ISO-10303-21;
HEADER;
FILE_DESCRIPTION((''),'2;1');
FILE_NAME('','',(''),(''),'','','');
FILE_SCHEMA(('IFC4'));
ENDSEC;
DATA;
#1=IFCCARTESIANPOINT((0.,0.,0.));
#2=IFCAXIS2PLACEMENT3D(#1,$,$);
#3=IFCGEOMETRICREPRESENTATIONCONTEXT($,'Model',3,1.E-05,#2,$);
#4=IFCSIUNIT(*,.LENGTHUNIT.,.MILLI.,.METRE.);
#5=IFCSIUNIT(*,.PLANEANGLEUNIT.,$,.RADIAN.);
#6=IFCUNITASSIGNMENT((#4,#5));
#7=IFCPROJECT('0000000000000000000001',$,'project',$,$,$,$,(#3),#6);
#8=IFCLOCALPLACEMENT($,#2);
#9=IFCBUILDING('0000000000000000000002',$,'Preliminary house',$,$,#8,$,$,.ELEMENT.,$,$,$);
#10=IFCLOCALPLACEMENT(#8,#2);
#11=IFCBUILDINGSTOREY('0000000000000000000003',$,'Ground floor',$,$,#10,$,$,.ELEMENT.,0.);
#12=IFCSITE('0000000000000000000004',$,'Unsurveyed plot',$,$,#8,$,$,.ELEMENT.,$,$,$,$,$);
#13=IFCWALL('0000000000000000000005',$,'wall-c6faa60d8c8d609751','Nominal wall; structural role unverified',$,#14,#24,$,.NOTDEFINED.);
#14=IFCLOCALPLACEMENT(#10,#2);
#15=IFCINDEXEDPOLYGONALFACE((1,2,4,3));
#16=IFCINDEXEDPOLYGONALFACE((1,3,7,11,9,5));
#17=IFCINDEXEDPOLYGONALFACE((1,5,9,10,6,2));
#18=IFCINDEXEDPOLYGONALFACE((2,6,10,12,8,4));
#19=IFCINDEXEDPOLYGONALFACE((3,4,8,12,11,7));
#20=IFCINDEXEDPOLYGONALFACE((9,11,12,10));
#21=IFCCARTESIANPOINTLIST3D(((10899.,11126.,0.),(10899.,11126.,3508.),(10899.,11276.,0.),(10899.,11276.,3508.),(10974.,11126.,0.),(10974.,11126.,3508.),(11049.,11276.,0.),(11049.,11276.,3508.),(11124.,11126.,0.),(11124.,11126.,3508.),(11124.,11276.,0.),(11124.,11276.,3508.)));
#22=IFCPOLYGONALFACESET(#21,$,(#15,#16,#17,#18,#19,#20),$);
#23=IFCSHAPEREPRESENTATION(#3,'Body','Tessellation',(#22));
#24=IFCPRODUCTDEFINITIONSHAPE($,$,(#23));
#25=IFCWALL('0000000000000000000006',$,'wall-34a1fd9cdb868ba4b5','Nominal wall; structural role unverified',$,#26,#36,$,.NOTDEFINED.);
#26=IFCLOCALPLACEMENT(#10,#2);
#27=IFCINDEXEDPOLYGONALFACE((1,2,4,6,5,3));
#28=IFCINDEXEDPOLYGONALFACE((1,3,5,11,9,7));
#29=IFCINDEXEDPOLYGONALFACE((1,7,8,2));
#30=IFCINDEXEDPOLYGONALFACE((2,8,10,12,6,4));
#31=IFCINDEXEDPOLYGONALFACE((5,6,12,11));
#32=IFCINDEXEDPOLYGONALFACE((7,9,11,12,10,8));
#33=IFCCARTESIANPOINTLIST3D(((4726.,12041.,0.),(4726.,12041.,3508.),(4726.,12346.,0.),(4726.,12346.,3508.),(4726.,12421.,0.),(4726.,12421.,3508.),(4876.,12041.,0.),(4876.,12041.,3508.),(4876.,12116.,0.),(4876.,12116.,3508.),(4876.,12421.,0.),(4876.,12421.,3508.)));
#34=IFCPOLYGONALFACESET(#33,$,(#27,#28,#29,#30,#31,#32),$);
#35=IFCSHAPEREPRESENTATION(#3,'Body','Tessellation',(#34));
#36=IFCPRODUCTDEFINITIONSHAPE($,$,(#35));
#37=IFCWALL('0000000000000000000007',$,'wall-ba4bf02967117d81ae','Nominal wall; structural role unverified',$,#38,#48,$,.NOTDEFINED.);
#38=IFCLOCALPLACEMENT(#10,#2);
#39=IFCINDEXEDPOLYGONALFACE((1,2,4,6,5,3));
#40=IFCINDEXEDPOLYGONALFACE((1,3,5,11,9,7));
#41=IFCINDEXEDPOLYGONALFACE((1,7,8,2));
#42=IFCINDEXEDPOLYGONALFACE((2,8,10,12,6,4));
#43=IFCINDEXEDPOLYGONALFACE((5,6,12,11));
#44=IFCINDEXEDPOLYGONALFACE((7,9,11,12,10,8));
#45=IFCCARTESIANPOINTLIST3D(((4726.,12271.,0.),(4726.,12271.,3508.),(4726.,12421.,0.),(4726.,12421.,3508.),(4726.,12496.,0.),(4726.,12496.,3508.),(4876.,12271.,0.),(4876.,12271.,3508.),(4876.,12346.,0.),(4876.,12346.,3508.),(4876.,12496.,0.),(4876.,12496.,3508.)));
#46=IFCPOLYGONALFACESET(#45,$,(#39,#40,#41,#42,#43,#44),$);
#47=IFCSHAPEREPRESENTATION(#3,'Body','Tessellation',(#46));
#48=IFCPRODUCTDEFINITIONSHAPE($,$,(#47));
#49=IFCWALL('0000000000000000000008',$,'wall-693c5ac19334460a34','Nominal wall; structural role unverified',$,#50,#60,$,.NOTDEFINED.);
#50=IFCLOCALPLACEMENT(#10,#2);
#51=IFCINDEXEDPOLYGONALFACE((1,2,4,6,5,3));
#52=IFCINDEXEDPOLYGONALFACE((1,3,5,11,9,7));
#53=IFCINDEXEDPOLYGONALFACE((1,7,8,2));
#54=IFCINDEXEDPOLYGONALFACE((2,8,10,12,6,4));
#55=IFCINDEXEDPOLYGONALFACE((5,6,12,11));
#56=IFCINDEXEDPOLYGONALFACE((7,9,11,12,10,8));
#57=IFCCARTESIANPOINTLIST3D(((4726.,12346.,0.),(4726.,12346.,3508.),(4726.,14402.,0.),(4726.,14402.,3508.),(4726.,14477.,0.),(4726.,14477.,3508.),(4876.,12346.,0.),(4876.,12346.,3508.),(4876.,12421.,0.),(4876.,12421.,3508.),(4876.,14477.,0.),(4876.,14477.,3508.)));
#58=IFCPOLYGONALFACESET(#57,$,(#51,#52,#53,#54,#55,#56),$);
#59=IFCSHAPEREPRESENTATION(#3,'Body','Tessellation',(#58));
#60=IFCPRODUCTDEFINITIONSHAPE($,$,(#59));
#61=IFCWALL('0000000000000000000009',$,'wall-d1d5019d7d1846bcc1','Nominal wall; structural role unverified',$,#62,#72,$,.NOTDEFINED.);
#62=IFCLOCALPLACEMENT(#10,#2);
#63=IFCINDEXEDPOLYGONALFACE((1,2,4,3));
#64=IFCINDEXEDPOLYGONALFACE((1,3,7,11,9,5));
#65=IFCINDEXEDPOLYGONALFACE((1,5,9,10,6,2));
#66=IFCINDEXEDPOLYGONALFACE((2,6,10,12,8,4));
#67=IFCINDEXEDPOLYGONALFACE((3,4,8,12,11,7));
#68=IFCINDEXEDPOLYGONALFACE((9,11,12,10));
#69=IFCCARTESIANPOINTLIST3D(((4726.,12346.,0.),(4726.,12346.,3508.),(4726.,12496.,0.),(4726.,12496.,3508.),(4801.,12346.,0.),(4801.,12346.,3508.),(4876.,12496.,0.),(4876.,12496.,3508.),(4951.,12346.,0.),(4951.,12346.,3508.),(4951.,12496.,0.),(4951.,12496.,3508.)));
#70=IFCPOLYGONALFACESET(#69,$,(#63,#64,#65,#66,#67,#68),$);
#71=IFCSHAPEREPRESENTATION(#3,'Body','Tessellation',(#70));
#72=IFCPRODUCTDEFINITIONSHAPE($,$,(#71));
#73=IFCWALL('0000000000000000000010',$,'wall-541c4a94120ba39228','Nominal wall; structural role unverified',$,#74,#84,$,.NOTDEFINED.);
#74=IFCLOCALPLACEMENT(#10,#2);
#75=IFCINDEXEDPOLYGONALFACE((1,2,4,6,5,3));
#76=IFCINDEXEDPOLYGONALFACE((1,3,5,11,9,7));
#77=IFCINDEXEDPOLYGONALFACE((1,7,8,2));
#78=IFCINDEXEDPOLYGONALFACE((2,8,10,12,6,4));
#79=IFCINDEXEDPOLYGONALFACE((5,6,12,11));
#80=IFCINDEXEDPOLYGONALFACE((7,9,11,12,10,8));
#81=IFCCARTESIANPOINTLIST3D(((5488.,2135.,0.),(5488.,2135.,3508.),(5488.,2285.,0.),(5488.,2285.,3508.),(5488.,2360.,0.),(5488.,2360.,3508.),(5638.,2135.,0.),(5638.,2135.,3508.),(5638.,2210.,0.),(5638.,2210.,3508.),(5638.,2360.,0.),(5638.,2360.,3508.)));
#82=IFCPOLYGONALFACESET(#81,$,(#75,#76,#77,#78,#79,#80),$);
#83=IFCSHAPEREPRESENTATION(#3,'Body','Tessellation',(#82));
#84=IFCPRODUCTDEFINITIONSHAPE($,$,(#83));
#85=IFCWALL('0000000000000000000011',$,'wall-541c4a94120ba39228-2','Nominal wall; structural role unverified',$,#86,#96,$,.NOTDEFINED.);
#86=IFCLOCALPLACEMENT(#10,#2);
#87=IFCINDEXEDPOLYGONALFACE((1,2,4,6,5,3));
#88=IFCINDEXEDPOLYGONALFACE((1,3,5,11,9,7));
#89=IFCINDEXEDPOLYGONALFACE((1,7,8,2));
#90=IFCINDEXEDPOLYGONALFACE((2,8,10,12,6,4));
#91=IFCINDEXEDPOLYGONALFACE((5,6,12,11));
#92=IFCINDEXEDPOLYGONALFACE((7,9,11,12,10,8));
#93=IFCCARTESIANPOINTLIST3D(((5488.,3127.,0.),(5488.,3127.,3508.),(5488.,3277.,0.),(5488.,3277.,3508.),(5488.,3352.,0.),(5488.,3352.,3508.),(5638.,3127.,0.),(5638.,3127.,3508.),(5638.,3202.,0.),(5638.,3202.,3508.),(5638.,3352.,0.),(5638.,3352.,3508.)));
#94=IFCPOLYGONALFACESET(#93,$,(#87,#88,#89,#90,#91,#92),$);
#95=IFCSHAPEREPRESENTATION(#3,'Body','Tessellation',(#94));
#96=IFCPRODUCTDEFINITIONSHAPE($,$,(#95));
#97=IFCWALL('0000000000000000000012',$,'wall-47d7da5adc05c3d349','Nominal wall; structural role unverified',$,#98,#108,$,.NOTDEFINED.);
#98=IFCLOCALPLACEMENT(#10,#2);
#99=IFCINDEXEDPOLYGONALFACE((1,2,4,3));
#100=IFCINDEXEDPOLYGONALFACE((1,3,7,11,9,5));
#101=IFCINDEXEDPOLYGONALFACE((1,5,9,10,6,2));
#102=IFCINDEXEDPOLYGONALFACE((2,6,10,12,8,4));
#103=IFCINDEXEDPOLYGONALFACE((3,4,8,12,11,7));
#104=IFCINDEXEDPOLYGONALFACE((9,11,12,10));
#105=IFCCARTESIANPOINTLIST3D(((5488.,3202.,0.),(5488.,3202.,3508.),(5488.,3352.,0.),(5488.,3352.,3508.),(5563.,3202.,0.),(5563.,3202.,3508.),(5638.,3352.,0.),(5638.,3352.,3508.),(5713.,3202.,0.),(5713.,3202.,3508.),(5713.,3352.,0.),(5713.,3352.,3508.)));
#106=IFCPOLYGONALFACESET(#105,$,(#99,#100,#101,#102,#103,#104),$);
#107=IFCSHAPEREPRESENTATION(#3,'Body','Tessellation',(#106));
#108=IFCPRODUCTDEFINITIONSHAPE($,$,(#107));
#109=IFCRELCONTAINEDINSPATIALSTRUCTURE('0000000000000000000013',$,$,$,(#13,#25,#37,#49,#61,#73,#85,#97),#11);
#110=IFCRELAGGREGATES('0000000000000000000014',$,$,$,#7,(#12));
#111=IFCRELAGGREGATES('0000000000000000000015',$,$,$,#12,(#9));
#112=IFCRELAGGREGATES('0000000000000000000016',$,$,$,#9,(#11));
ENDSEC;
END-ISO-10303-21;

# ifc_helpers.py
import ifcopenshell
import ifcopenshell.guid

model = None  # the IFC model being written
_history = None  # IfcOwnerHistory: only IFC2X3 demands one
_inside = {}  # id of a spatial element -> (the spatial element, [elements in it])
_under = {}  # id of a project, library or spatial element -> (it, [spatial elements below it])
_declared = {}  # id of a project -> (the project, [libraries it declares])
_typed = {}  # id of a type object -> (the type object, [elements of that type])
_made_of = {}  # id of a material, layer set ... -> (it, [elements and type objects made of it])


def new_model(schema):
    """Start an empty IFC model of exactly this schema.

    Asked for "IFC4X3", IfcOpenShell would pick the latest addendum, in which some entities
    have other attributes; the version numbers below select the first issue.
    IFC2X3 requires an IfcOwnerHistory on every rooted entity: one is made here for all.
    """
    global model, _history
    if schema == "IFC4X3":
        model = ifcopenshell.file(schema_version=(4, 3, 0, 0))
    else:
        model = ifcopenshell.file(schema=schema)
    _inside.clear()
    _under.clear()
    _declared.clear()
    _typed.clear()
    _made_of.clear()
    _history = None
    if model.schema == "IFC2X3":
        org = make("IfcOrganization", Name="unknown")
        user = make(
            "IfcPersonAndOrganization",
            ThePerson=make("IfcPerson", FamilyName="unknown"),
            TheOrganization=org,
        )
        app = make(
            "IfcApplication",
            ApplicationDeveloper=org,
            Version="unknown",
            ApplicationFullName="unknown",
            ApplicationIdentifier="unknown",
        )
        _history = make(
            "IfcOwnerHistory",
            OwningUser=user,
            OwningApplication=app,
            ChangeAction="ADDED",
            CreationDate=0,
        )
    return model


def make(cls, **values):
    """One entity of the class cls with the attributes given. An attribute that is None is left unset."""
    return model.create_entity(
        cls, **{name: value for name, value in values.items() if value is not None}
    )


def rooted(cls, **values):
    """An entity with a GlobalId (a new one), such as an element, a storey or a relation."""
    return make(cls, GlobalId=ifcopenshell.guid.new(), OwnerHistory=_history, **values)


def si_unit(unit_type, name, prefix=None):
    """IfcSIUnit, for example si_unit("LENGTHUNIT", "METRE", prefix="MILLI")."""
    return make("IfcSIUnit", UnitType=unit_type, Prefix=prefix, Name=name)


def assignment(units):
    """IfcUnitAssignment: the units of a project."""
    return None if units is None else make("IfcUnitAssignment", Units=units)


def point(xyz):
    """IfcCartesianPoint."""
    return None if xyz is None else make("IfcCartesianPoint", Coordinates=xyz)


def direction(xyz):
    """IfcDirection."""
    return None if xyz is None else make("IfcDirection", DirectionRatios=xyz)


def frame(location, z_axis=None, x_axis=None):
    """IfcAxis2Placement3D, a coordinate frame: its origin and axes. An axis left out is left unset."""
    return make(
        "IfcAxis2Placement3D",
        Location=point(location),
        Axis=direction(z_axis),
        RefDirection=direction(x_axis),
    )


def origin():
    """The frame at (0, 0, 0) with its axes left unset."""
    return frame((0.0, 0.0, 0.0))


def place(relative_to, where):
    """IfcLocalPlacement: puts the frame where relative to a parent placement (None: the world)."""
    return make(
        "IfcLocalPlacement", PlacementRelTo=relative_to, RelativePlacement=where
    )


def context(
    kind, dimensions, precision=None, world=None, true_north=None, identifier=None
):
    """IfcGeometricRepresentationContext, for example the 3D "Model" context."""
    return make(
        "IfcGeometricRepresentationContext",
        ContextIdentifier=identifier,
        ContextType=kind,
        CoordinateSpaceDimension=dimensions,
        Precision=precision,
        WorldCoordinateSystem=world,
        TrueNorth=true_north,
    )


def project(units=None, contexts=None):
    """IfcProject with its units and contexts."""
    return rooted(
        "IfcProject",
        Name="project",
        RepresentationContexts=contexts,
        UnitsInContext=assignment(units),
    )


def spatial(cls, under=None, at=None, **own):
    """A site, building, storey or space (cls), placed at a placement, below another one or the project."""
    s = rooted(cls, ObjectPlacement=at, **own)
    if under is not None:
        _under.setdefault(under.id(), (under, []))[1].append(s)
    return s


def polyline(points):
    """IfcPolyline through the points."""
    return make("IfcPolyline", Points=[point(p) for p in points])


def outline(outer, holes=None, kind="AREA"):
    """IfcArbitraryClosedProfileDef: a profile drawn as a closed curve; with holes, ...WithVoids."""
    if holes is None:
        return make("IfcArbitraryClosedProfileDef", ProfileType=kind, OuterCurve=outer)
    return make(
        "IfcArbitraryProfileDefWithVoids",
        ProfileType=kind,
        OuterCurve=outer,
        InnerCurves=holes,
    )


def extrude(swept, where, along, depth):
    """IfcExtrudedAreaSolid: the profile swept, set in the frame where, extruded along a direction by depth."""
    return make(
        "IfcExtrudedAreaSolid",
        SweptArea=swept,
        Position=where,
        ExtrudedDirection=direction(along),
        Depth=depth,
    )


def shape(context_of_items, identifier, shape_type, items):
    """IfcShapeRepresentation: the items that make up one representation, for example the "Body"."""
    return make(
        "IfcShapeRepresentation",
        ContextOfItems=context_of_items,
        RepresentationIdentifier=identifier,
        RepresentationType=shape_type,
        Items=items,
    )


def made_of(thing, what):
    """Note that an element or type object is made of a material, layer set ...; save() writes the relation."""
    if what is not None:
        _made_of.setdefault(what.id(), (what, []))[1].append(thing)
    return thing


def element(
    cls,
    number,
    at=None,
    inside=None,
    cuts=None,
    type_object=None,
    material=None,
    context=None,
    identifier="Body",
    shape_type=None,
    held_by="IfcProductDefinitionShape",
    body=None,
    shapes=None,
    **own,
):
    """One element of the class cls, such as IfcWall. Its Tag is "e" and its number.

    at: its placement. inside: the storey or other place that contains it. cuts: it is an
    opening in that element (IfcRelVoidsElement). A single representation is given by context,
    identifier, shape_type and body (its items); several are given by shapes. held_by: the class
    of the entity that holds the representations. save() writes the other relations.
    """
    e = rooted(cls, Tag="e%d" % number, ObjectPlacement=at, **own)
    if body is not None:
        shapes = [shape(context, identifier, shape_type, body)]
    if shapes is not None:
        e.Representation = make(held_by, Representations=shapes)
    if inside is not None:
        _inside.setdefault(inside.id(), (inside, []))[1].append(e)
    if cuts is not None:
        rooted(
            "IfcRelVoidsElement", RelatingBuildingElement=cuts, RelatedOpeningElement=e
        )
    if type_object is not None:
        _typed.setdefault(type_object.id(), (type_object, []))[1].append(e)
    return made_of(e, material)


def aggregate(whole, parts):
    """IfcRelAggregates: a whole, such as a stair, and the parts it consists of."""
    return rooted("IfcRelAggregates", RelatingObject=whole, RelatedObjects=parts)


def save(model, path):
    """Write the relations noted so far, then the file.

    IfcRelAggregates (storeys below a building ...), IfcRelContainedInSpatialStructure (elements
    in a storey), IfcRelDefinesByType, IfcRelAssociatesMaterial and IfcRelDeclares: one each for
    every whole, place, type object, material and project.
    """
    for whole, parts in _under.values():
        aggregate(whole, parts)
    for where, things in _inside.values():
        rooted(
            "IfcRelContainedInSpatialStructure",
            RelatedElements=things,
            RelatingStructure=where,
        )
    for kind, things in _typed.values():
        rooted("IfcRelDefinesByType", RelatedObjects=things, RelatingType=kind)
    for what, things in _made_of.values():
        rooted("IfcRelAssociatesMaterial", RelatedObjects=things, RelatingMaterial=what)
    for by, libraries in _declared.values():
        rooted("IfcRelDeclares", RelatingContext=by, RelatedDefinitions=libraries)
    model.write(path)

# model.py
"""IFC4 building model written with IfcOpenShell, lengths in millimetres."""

from ifc_helpers import new_model, si_unit, origin, place, context, project, spatial, polyline, outline, extrude, element, save


model = new_model("IFC4")

# Units and contexts
model_context = context("Model", 3, precision=1e-05, world=origin())
ifc_project = project(units=[si_unit("LENGTHUNIT", "METRE", prefix="MILLI"), si_unit("PLANEANGLEUNIT", "RADIAN")], contexts=[model_context])

# Site, building, storey
placement_1 = place(None, origin())
site = spatial("IfcSite", under=ifc_project, at=placement_1, Name="Unsurveyed plot", CompositionType="ELEMENT")
building = spatial("IfcBuilding", under=site, at=placement_1, Name="Preliminary house", CompositionType="ELEMENT")
placement_2 = place(placement_1, origin())
storey = spatial("IfcBuildingStorey", under=building, at=placement_2, Name="Ground floor", CompositionType="ELEMENT", Elevation=0.0)

# Walls
element("IfcWall", 1, at=placement_2, inside=storey, Name="wall-c6faa60d8c8d609751", Description="Nominal wall; structural role unverified", PredefinedType="NOTDEFINED", context=model_context, shape_type="SweptSolid", body=[
    extrude(outline(polyline([(11049.0, 11276.0), (11124.0, 11276.0), (11124.0, 11126.0), (10974.0, 11126.0), (10899.0, 11126.0), (10899.0, 11276.0), (11049.0, 11276.0)])), origin(), (0.0, 0.0, 1.0), 3508.0),
])
element("IfcWall", 2, at=placement_2, inside=storey, Name="wall-34a1fd9cdb868ba4b5", Description="Nominal wall; structural role unverified", PredefinedType="NOTDEFINED", context=model_context, shape_type="SweptSolid", body=[
    extrude(outline(polyline([(4726.0, 12346.0), (4726.0, 12421.0), (4876.0, 12421.0), (4876.0, 12116.0), (4876.0, 12041.0), (4726.0, 12041.0), (4726.0, 12346.0)])), origin(), (0.0, 0.0, 1.0), 3508.0),
])
element("IfcWall", 3, at=placement_2, inside=storey, Name="wall-ba4bf02967117d81ae", Description="Nominal wall; structural role unverified", PredefinedType="NOTDEFINED", context=model_context, shape_type="SweptSolid", body=[
    extrude(outline(polyline([(4726.0, 12421.0), (4726.0, 12496.0), (4876.0, 12496.0), (4876.0, 12346.0), (4876.0, 12271.0), (4726.0, 12271.0), (4726.0, 12421.0)])), origin(), (0.0, 0.0, 1.0), 3508.0),
])
element("IfcWall", 4, at=placement_2, inside=storey, Name="wall-693c5ac19334460a34", Description="Nominal wall; structural role unverified", PredefinedType="NOTDEFINED", context=model_context, shape_type="SweptSolid", body=[
    extrude(outline(polyline([(4726.0, 14402.0), (4726.0, 14477.0), (4876.0, 14477.0), (4876.0, 12421.0), (4876.0, 12346.0), (4726.0, 12346.0), (4726.0, 14402.0)])), origin(), (0.0, 0.0, 1.0), 3508.0),
])
element("IfcWall", 5, at=placement_2, inside=storey, Name="wall-d1d5019d7d1846bcc1", Description="Nominal wall; structural role unverified", PredefinedType="NOTDEFINED", context=model_context, shape_type="SweptSolid", body=[
    extrude(outline(polyline([(4876.0, 12496.0), (4951.0, 12496.0), (4951.0, 12346.0), (4801.0, 12346.0), (4726.0, 12346.0), (4726.0, 12496.0), (4876.0, 12496.0)])), origin(), (0.0, 0.0, 1.0), 3508.0),
])

# Wall
element("IfcWall", 6, at=placement_2, inside=storey, Name="wall-541c4a94120ba39228", Description="Nominal wall; structural role unverified", PredefinedType="NOTDEFINED", context=model_context, shape_type="SweptSolid", body=[
    extrude(outline(polyline([(5488.0, 2285.0), (5488.0, 2360.0), (5638.0, 2360.0), (5638.0, 2210.0), (5638.0, 2135.0), (5488.0, 2135.0), (5488.0, 2285.0)])), origin(), (0.0, 0.0, 1.0), 3508.0),
])

# Wall
element("IfcWall", 7, at=placement_2, inside=storey, Name="wall-541c4a94120ba39228-2", Description="Nominal wall; structural role unverified", PredefinedType="NOTDEFINED", context=model_context, shape_type="SweptSolid", body=[
    extrude(outline(polyline([(5488.0, 3277.0), (5488.0, 3352.0), (5638.0, 3352.0), (5638.0, 3202.0), (5638.0, 3127.0), (5488.0, 3127.0), (5488.0, 3277.0)])), origin(), (0.0, 0.0, 1.0), 3508.0),
])

# Wall
element("IfcWall", 8, at=placement_2, inside=storey, Name="wall-47d7da5adc05c3d349", Description="Nominal wall; structural role unverified", PredefinedType="NOTDEFINED", context=model_context, shape_type="SweptSolid", body=[
    extrude(outline(polyline([(5638.0, 3352.0), (5713.0, 3352.0), (5713.0, 3202.0), (5563.0, 3202.0), (5488.0, 3202.0), (5488.0, 3352.0), (5638.0, 3352.0)])), origin(), (0.0, 0.0, 1.0), 3508.0),
])

save(model, "model.ifc")
